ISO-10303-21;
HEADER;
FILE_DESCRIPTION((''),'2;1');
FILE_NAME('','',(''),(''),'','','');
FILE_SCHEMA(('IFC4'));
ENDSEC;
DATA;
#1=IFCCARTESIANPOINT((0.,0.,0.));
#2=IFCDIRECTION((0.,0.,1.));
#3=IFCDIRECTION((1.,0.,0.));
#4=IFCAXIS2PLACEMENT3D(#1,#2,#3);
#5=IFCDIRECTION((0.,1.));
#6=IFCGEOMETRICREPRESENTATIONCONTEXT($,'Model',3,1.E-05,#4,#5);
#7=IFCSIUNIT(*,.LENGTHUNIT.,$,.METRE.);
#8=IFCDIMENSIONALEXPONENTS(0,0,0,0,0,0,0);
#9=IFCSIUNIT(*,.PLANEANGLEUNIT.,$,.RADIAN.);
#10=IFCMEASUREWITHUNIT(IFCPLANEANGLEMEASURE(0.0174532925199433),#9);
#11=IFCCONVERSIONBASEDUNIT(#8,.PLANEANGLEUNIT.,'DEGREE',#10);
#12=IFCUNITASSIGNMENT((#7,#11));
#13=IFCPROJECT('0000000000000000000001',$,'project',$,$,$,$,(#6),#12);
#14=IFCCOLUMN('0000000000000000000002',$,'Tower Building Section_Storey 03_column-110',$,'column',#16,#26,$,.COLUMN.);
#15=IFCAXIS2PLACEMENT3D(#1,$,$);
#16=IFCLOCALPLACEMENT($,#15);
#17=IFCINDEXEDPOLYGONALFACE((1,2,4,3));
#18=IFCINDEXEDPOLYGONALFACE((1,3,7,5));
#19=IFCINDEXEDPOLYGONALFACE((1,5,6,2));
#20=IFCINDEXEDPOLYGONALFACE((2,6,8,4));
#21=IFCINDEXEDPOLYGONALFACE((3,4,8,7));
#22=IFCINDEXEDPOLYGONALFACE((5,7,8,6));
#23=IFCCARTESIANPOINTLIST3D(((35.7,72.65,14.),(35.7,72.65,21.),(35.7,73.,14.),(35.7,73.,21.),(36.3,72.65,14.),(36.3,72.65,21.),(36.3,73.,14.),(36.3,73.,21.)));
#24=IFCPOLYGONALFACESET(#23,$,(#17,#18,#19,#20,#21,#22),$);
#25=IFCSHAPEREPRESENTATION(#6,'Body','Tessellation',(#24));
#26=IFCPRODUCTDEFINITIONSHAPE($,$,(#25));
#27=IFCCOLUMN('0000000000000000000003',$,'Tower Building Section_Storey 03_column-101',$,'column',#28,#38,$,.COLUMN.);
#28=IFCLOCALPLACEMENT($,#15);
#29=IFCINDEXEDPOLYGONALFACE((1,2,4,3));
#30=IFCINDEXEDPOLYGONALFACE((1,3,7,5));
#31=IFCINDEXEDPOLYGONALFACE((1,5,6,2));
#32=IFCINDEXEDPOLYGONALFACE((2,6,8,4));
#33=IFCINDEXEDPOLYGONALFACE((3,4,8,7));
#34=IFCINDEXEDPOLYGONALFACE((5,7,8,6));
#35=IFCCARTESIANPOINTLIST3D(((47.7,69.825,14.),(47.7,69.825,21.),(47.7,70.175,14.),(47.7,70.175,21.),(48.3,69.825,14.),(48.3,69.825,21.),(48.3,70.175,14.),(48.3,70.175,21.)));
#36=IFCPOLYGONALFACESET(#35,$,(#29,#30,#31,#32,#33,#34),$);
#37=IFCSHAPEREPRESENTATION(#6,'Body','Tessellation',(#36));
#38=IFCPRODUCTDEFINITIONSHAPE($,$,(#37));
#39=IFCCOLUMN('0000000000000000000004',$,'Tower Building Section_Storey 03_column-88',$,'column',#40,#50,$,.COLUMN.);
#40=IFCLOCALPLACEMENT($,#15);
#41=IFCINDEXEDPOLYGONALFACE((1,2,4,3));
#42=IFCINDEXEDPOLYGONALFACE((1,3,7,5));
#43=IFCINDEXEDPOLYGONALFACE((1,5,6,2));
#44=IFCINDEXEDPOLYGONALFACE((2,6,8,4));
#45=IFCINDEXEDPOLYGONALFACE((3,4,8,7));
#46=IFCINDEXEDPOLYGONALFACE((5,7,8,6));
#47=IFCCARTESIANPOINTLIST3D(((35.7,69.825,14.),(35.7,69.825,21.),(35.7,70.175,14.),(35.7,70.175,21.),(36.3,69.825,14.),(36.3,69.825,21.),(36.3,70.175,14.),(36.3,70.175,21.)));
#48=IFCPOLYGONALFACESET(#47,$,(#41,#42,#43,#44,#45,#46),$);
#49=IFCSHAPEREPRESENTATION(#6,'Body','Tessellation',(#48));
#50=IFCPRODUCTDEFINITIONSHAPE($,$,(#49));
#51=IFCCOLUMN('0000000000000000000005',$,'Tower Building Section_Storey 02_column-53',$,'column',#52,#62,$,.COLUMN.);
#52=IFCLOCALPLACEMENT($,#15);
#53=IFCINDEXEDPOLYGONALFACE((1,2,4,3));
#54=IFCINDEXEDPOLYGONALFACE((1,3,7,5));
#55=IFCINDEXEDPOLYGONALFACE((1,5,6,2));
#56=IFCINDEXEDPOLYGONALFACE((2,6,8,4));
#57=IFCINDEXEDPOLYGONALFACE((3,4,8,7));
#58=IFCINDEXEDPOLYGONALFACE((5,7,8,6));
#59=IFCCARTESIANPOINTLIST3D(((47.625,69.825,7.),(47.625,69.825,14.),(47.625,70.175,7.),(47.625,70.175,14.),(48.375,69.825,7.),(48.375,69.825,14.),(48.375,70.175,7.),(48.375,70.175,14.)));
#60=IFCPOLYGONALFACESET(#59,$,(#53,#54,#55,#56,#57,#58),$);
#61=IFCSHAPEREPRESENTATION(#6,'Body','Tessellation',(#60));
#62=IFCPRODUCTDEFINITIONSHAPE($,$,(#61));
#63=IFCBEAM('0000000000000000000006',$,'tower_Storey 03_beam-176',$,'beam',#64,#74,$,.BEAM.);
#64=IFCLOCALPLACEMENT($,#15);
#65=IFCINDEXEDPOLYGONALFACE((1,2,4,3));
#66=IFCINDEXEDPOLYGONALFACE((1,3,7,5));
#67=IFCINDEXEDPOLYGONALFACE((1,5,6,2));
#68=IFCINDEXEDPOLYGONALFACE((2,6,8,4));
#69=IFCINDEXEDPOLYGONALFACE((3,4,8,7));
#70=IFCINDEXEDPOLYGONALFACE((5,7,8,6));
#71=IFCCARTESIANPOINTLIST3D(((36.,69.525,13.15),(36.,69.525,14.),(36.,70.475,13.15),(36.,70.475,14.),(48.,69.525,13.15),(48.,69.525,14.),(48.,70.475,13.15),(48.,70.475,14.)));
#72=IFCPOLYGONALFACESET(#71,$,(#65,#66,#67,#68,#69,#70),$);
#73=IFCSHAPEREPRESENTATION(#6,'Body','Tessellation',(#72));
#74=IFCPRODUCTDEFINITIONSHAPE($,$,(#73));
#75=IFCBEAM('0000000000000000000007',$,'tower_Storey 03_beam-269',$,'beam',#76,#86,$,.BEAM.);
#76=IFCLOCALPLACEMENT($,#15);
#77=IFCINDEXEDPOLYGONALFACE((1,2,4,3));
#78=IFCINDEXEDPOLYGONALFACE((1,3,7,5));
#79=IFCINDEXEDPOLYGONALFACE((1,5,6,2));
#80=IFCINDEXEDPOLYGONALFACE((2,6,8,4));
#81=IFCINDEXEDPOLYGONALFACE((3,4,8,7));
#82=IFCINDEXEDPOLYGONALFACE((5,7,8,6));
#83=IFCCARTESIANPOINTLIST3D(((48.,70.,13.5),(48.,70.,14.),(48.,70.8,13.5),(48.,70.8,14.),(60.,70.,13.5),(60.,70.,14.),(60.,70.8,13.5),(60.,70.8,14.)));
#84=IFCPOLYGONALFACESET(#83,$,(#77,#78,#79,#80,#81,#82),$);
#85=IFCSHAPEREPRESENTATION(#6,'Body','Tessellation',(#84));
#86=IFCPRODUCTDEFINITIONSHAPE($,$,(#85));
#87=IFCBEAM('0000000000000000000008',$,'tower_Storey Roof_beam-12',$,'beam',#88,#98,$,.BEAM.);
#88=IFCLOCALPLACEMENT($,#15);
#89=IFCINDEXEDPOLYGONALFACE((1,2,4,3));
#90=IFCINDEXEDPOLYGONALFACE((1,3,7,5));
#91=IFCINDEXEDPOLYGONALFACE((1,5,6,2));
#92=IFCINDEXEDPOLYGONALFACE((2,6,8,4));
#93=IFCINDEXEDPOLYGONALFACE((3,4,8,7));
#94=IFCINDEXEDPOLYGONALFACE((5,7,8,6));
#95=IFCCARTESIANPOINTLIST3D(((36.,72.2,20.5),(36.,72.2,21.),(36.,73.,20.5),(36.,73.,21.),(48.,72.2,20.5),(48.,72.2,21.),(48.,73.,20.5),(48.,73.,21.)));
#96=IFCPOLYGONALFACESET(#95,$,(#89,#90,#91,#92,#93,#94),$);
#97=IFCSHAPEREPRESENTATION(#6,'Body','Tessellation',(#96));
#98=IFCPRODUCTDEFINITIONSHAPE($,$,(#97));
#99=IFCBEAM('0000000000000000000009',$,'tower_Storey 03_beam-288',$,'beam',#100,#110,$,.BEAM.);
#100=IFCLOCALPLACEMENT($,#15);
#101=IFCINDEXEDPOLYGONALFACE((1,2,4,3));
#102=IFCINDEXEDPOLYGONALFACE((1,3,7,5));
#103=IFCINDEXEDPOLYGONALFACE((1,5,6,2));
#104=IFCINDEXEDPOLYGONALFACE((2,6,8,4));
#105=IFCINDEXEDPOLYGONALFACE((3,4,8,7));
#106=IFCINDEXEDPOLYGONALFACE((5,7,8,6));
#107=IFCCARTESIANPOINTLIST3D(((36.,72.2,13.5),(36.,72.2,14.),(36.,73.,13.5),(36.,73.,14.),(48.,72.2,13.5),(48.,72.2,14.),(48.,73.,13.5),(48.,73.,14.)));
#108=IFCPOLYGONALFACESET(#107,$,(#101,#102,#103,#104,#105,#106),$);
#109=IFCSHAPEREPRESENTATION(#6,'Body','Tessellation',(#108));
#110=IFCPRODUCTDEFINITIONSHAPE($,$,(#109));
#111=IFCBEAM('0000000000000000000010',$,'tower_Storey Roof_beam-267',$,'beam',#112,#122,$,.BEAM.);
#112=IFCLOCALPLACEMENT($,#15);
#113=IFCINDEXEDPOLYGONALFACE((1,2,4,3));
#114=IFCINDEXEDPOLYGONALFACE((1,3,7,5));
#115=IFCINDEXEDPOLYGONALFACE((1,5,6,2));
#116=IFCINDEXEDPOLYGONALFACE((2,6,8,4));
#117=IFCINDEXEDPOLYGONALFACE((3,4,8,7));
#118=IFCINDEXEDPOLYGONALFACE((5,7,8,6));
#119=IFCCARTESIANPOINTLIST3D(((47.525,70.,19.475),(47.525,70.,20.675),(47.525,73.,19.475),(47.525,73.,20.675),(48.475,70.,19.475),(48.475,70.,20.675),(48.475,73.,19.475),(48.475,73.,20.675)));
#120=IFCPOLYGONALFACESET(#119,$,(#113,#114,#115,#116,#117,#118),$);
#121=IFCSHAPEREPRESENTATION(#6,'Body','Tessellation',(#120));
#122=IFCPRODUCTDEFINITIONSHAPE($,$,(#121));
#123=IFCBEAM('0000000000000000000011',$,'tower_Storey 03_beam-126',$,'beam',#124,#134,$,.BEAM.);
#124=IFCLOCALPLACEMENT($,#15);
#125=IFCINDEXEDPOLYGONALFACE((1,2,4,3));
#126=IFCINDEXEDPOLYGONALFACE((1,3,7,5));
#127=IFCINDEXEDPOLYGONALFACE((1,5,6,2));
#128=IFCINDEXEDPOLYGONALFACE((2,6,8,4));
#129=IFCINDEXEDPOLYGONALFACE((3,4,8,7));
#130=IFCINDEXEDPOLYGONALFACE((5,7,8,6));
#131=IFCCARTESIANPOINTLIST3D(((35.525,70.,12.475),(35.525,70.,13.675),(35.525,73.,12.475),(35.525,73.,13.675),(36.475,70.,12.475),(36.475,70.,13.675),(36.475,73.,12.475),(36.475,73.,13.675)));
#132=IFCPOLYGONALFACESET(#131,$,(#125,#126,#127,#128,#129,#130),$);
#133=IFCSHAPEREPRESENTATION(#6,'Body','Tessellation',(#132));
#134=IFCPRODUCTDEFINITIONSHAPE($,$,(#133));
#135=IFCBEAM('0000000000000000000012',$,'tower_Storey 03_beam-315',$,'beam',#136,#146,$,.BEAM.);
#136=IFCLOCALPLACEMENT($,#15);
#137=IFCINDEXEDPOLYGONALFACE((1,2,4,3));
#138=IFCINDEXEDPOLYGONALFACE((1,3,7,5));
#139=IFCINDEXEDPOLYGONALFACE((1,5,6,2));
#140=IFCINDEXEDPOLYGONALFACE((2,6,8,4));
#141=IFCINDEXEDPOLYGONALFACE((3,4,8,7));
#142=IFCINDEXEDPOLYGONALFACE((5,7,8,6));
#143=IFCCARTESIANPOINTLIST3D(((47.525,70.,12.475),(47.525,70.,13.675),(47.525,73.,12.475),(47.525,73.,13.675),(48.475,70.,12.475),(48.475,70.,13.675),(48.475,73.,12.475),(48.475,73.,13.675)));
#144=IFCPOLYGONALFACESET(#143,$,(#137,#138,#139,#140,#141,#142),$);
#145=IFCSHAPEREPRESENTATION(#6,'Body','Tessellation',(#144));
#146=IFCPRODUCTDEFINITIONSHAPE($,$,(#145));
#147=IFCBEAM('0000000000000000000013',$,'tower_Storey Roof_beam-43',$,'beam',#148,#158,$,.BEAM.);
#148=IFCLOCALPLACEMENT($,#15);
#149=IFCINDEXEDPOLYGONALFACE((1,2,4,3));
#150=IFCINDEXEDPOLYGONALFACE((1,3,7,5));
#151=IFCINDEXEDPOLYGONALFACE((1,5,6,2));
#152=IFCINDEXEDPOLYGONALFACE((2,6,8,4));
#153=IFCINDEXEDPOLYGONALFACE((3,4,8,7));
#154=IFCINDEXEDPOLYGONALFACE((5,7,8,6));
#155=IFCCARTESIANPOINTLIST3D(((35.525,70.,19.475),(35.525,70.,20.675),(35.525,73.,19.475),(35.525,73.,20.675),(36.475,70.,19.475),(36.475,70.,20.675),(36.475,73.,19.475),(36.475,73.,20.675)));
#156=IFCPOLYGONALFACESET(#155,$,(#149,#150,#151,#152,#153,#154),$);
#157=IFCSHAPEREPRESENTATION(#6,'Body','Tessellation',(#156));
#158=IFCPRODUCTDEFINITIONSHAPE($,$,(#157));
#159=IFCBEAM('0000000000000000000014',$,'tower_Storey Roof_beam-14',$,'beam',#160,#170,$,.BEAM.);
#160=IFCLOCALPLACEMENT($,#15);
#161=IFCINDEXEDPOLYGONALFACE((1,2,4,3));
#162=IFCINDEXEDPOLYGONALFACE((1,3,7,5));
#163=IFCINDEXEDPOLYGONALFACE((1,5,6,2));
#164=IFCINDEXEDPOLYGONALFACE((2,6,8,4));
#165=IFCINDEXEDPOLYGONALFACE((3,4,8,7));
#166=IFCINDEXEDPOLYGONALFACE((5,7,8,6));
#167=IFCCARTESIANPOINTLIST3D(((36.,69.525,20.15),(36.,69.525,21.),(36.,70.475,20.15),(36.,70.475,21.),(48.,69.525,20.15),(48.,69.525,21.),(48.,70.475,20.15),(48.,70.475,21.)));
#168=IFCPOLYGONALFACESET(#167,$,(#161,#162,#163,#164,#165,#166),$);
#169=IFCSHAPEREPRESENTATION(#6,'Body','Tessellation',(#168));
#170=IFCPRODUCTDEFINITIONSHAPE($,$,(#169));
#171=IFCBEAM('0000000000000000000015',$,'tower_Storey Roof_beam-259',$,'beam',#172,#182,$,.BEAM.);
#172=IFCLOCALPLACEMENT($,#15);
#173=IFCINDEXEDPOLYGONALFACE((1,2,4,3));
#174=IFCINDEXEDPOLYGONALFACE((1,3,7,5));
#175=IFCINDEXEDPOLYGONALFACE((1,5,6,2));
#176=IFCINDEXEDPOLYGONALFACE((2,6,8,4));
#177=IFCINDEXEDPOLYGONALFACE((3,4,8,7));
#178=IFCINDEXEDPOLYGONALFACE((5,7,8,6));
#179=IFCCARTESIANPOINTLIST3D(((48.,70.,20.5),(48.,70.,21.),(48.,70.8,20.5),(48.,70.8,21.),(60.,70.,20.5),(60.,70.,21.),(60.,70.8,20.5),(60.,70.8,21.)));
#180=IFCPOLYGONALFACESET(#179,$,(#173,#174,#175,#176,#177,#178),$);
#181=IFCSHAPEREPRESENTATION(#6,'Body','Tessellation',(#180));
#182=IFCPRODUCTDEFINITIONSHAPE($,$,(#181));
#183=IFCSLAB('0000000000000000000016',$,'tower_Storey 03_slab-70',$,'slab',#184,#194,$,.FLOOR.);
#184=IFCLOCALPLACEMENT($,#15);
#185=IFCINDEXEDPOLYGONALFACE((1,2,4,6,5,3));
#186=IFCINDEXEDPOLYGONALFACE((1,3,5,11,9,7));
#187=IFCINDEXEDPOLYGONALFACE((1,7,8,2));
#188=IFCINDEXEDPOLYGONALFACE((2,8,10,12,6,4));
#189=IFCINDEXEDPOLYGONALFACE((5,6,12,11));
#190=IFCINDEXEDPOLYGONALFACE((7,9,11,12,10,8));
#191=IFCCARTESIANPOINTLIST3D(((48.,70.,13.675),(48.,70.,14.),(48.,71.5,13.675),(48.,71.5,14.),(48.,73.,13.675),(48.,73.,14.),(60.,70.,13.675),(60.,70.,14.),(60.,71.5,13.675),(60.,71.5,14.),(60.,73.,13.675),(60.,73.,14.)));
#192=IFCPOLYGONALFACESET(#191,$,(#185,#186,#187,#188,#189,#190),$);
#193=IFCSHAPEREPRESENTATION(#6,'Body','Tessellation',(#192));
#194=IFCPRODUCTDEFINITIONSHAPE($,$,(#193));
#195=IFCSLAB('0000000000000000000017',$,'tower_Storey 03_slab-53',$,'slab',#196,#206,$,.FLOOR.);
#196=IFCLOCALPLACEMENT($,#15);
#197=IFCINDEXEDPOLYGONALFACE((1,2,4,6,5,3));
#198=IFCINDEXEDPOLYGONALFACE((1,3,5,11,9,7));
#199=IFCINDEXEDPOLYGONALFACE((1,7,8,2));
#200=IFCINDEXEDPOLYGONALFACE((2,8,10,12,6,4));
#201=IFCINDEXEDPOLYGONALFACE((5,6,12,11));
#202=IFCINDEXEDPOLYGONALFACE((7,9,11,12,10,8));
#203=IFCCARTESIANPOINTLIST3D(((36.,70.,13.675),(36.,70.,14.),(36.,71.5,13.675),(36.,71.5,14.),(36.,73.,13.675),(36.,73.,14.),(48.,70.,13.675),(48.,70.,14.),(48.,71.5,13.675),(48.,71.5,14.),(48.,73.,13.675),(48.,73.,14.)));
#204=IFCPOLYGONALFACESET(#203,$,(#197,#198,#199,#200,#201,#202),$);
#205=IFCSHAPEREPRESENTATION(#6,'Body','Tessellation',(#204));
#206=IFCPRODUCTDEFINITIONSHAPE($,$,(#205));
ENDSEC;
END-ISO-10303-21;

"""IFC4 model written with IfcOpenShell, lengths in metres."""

from ifc_helpers import new_model, entity, si_unit, converted_unit, direction, frame, origin_with_axes, place, context, project, polyline, outline, extrude, element, save


model = new_model("IFC4")

# Units and contexts
model_context = context("Model", 3, precision=1e-05, world=origin_with_axes(), true_north=direction((0.0, 1.0)))
ifc_project = project(units=[si_unit("LENGTHUNIT", "METRE"), converted_unit("PLANEANGLEUNIT", "DEGREE", entity("IfcPlaneAngleMeasure", 0.0174532925199433), si_unit("PLANEANGLEUNIT", "RADIAN"), dimensions=[0, 0, 0, 0, 0, 0, 0])], contexts=[model_context])

# Columns
placement_1 = place(None, origin_with_axes())
placement_2 = place(placement_1, frame((0.0, 0.0, 14.0), z_axis=(0.0, 0.0, 1.0), x_axis=(1.0, 0.0, 0.0)))
for number, where, z_axis, x_axis, name in (
    (1, (36.0, 72.825, 0.0), (0.0, 0.0, 1.0), (1.0, 0.0, 0.0), "Tower Building Section_Storey 03_column-110"),
    (2, (48.0, 70.0, 0.0), (0.0, 0.0, 1.0), (1.0, 0.0, 0.0), "Tower Building Section_Storey 03_column-101"),
    (3, (36.0, 70.0, 0.0), (0.0, 0.0, 1.0), (1.0, 0.0, 0.0), "Tower Building Section_Storey 03_column-88"),
):
    element("IfcColumn", number, at=place(placement_2, frame(where, z_axis=z_axis, x_axis=x_axis)), Name=name, ObjectType="column", PredefinedType="COLUMN", context=model_context, body=[
        extrude(outline(polyline([(-0.3, -0.175, 0.0), (0.3, -0.175, 0.0), (0.3, 0.175, 0.0), (-0.3, 0.175, 0.0), (-0.3, -0.175, 0.0)])), origin_with_axes(), (0.0, 0.0, 1.0), 7.0),
    ])
placement_3 = place(placement_1, frame((0.0, 0.0, 7.0), z_axis=(0.0, 0.0, 1.0), x_axis=(1.0, 0.0, 0.0)))
column_placement = place(placement_3, frame((48.0, 70.0, 0.0), z_axis=(0.0, 0.0, 1.0), x_axis=(1.0, 0.0, 0.0)))
element("IfcColumn", 4, at=column_placement, Name="Tower Building Section_Storey 02_column-53", ObjectType="column", PredefinedType="COLUMN", context=model_context, body=[
    extrude(outline(polyline([(-0.375, -0.175, 0.0), (0.375, -0.175, 0.0), (0.375, 0.175, 0.0), (-0.375, 0.175, 0.0), (-0.375, -0.175, 0.0)])), origin_with_axes(), (0.0, 0.0, 1.0), 7.0),
])

# Beams
beam_1_placement = place(placement_2, frame((36.0, 70.0, -0.425), z_axis=(1.0, 0.0, 0.0), x_axis=(0.0, 1.0, 0.0)))
element("IfcBeam", 5, at=beam_1_placement, Name="tower_Storey 03_beam-176", ObjectType="beam", PredefinedType="BEAM", context=model_context, body=[
    extrude(outline(polyline([(0.475, 0.425, 0.0), (-0.475, 0.425, 0.0), (-0.475, -0.425, 0.0), (0.475, -0.425, 0.0), (0.475, 0.425, 0.0)])), origin_with_axes(), (0.0, 0.0, 1.0), 12.0),
])
beam_2_placement = place(placement_2, frame((48.0, 70.4, -0.25), z_axis=(1.0, 0.0, 0.0), x_axis=(0.0, 1.0, 0.0)))
element("IfcBeam", 6, at=beam_2_placement, Name="tower_Storey 03_beam-269", ObjectType="beam", PredefinedType="BEAM", context=model_context, body=[
    extrude(outline(polyline([(0.4, 0.25, 0.0), (-0.4, 0.25, 0.0), (-0.4, -0.25, 0.0), (0.4, -0.25, 0.0), (0.4, 0.25, 0.0)])), origin_with_axes(), (0.0, 0.0, 1.0), 12.0),
])
placement_4 = place(placement_1, frame((0.0, 0.0, 21.0), z_axis=(0.0, 0.0, 1.0), x_axis=(1.0, 0.0, 0.0)))
beam_3_placement = place(placement_4, frame((36.0, 72.6, -0.25), z_axis=(1.0, 0.0, 0.0), x_axis=(0.0, 1.0, 0.0)))
element("IfcBeam", 7, at=beam_3_placement, Name="tower_Storey Roof_beam-12", ObjectType="beam", PredefinedType="BEAM", context=model_context, body=[
    extrude(outline(polyline([(0.4, 0.25, 0.0), (-0.4, 0.25, 0.0), (-0.4, -0.25, 0.0), (0.4, -0.25, 0.0), (0.4, 0.25, 0.0)])), origin_with_axes(), (0.0, 0.0, 1.0), 12.0),
])
beam_4_placement = place(placement_2, frame((36.0, 72.6, -0.25), z_axis=(1.0, 0.0, 0.0), x_axis=(0.0, 1.0, 0.0)))
element("IfcBeam", 8, at=beam_4_placement, Name="tower_Storey 03_beam-288", ObjectType="beam", PredefinedType="BEAM", context=model_context, body=[
    extrude(outline(polyline([(0.4, 0.25, 0.0), (-0.4, 0.25, 0.0), (-0.4, -0.25, 0.0), (0.4, -0.25, 0.0), (0.4, 0.25, 0.0)])), origin_with_axes(), (0.0, 0.0, 1.0), 12.0),
])
beam_5_placement = place(placement_4, frame((48.0, 70.0, -0.925), z_axis=(0.0, 1.0, 0.0), x_axis=(-1.0, 0.0, 0.0)))
element("IfcBeam", 9, at=beam_5_placement, Name="tower_Storey Roof_beam-267", ObjectType="beam", PredefinedType="BEAM", context=model_context, body=[
    extrude(outline(polyline([(0.475, 0.6, 0.0), (-0.475, 0.6, 0.0), (-0.475, -0.6, 0.0), (0.475, -0.6, 0.0), (0.475, 0.6, 0.0)])), origin_with_axes(), (0.0, 0.0, 1.0), 3.0),
])
for number, where, z_axis, x_axis, name in (
    (10, (36.0, 70.0, -0.925), (0.0, 1.0, 0.0), (-1.0, 0.0, 0.0), "tower_Storey 03_beam-126"),
    (11, (48.0, 70.0, -0.925), (0.0, 1.0, 0.0), (-1.0, 0.0, 0.0), "tower_Storey 03_beam-315"),
):
    element("IfcBeam", number, at=place(placement_2, frame(where, z_axis=z_axis, x_axis=x_axis)), Name=name, ObjectType="beam", PredefinedType="BEAM", context=model_context, body=[
        extrude(outline(polyline([(0.475, 0.6, 0.0), (-0.475, 0.6, 0.0), (-0.475, -0.6, 0.0), (0.475, -0.6, 0.0), (0.475, 0.6, 0.0)])), origin_with_axes(), (0.0, 0.0, 1.0), 3.0),
    ])
beam_6_placement = place(placement_4, frame((36.0, 70.0, -0.925), z_axis=(0.0, 1.0, 0.0), x_axis=(-1.0, 0.0, 0.0)))
element("IfcBeam", 12, at=beam_6_placement, Name="tower_Storey Roof_beam-43", ObjectType="beam", PredefinedType="BEAM", context=model_context, body=[
    extrude(outline(polyline([(0.475, 0.6, 0.0), (-0.475, 0.6, 0.0), (-0.475, -0.6, 0.0), (0.475, -0.6, 0.0), (0.475, 0.6, 0.0)])), origin_with_axes(), (0.0, 0.0, 1.0), 3.0),
])
beam_7_placement = place(placement_4, frame((36.0, 70.0, -0.425), z_axis=(1.0, 0.0, 0.0), x_axis=(0.0, 1.0, 0.0)))
element("IfcBeam", 13, at=beam_7_placement, Name="tower_Storey Roof_beam-14", ObjectType="beam", PredefinedType="BEAM", context=model_context, body=[
    extrude(outline(polyline([(0.475, 0.425, 0.0), (-0.475, 0.425, 0.0), (-0.475, -0.425, 0.0), (0.475, -0.425, 0.0), (0.475, 0.425, 0.0)])), origin_with_axes(), (0.0, 0.0, 1.0), 12.0),
])
beam_8_placement = place(placement_4, frame((48.0, 70.4, -0.25), z_axis=(1.0, 0.0, 0.0), x_axis=(0.0, 1.0, 0.0)))
element("IfcBeam", 14, at=beam_8_placement, Name="tower_Storey Roof_beam-259", ObjectType="beam", PredefinedType="BEAM", context=model_context, body=[
    extrude(outline(polyline([(0.4, 0.25, 0.0), (-0.4, 0.25, 0.0), (-0.4, -0.25, 0.0), (0.4, -0.25, 0.0), (0.4, 0.25, 0.0)])), origin_with_axes(), (0.0, 0.0, 1.0), 12.0),
])

# Slabs
for number, where, z_axis, x_axis, name in (
    (15, (54.0, 71.5, -0.325), (0.0, 0.0, 1.0), (1.0, 0.0, 0.0), "tower_Storey 03_slab-70"),
    (16, (42.0, 71.5, -0.325), (0.0, 0.0, 1.0), (1.0, 0.0, 0.0), "tower_Storey 03_slab-53"),
):
    element("IfcSlab", number, at=place(placement_2, frame(where, z_axis=z_axis, x_axis=x_axis)), Name=name, ObjectType="slab", PredefinedType="FLOOR", context=model_context, body=[
        extrude(outline(polyline([(-6.0, -1.5, 0.0), (6.0, -1.5, 0.0), (6.0, 0.0, 0.0), (6.0, 1.5, 0.0), (-6.0, 1.5, 0.0), (-6.0, 0.0, 0.0), (-6.0, -1.5, 0.0)])), origin_with_axes(), (0.0, 0.0, 1.0), 0.325),
    ])

save(model, "model.ifc")
